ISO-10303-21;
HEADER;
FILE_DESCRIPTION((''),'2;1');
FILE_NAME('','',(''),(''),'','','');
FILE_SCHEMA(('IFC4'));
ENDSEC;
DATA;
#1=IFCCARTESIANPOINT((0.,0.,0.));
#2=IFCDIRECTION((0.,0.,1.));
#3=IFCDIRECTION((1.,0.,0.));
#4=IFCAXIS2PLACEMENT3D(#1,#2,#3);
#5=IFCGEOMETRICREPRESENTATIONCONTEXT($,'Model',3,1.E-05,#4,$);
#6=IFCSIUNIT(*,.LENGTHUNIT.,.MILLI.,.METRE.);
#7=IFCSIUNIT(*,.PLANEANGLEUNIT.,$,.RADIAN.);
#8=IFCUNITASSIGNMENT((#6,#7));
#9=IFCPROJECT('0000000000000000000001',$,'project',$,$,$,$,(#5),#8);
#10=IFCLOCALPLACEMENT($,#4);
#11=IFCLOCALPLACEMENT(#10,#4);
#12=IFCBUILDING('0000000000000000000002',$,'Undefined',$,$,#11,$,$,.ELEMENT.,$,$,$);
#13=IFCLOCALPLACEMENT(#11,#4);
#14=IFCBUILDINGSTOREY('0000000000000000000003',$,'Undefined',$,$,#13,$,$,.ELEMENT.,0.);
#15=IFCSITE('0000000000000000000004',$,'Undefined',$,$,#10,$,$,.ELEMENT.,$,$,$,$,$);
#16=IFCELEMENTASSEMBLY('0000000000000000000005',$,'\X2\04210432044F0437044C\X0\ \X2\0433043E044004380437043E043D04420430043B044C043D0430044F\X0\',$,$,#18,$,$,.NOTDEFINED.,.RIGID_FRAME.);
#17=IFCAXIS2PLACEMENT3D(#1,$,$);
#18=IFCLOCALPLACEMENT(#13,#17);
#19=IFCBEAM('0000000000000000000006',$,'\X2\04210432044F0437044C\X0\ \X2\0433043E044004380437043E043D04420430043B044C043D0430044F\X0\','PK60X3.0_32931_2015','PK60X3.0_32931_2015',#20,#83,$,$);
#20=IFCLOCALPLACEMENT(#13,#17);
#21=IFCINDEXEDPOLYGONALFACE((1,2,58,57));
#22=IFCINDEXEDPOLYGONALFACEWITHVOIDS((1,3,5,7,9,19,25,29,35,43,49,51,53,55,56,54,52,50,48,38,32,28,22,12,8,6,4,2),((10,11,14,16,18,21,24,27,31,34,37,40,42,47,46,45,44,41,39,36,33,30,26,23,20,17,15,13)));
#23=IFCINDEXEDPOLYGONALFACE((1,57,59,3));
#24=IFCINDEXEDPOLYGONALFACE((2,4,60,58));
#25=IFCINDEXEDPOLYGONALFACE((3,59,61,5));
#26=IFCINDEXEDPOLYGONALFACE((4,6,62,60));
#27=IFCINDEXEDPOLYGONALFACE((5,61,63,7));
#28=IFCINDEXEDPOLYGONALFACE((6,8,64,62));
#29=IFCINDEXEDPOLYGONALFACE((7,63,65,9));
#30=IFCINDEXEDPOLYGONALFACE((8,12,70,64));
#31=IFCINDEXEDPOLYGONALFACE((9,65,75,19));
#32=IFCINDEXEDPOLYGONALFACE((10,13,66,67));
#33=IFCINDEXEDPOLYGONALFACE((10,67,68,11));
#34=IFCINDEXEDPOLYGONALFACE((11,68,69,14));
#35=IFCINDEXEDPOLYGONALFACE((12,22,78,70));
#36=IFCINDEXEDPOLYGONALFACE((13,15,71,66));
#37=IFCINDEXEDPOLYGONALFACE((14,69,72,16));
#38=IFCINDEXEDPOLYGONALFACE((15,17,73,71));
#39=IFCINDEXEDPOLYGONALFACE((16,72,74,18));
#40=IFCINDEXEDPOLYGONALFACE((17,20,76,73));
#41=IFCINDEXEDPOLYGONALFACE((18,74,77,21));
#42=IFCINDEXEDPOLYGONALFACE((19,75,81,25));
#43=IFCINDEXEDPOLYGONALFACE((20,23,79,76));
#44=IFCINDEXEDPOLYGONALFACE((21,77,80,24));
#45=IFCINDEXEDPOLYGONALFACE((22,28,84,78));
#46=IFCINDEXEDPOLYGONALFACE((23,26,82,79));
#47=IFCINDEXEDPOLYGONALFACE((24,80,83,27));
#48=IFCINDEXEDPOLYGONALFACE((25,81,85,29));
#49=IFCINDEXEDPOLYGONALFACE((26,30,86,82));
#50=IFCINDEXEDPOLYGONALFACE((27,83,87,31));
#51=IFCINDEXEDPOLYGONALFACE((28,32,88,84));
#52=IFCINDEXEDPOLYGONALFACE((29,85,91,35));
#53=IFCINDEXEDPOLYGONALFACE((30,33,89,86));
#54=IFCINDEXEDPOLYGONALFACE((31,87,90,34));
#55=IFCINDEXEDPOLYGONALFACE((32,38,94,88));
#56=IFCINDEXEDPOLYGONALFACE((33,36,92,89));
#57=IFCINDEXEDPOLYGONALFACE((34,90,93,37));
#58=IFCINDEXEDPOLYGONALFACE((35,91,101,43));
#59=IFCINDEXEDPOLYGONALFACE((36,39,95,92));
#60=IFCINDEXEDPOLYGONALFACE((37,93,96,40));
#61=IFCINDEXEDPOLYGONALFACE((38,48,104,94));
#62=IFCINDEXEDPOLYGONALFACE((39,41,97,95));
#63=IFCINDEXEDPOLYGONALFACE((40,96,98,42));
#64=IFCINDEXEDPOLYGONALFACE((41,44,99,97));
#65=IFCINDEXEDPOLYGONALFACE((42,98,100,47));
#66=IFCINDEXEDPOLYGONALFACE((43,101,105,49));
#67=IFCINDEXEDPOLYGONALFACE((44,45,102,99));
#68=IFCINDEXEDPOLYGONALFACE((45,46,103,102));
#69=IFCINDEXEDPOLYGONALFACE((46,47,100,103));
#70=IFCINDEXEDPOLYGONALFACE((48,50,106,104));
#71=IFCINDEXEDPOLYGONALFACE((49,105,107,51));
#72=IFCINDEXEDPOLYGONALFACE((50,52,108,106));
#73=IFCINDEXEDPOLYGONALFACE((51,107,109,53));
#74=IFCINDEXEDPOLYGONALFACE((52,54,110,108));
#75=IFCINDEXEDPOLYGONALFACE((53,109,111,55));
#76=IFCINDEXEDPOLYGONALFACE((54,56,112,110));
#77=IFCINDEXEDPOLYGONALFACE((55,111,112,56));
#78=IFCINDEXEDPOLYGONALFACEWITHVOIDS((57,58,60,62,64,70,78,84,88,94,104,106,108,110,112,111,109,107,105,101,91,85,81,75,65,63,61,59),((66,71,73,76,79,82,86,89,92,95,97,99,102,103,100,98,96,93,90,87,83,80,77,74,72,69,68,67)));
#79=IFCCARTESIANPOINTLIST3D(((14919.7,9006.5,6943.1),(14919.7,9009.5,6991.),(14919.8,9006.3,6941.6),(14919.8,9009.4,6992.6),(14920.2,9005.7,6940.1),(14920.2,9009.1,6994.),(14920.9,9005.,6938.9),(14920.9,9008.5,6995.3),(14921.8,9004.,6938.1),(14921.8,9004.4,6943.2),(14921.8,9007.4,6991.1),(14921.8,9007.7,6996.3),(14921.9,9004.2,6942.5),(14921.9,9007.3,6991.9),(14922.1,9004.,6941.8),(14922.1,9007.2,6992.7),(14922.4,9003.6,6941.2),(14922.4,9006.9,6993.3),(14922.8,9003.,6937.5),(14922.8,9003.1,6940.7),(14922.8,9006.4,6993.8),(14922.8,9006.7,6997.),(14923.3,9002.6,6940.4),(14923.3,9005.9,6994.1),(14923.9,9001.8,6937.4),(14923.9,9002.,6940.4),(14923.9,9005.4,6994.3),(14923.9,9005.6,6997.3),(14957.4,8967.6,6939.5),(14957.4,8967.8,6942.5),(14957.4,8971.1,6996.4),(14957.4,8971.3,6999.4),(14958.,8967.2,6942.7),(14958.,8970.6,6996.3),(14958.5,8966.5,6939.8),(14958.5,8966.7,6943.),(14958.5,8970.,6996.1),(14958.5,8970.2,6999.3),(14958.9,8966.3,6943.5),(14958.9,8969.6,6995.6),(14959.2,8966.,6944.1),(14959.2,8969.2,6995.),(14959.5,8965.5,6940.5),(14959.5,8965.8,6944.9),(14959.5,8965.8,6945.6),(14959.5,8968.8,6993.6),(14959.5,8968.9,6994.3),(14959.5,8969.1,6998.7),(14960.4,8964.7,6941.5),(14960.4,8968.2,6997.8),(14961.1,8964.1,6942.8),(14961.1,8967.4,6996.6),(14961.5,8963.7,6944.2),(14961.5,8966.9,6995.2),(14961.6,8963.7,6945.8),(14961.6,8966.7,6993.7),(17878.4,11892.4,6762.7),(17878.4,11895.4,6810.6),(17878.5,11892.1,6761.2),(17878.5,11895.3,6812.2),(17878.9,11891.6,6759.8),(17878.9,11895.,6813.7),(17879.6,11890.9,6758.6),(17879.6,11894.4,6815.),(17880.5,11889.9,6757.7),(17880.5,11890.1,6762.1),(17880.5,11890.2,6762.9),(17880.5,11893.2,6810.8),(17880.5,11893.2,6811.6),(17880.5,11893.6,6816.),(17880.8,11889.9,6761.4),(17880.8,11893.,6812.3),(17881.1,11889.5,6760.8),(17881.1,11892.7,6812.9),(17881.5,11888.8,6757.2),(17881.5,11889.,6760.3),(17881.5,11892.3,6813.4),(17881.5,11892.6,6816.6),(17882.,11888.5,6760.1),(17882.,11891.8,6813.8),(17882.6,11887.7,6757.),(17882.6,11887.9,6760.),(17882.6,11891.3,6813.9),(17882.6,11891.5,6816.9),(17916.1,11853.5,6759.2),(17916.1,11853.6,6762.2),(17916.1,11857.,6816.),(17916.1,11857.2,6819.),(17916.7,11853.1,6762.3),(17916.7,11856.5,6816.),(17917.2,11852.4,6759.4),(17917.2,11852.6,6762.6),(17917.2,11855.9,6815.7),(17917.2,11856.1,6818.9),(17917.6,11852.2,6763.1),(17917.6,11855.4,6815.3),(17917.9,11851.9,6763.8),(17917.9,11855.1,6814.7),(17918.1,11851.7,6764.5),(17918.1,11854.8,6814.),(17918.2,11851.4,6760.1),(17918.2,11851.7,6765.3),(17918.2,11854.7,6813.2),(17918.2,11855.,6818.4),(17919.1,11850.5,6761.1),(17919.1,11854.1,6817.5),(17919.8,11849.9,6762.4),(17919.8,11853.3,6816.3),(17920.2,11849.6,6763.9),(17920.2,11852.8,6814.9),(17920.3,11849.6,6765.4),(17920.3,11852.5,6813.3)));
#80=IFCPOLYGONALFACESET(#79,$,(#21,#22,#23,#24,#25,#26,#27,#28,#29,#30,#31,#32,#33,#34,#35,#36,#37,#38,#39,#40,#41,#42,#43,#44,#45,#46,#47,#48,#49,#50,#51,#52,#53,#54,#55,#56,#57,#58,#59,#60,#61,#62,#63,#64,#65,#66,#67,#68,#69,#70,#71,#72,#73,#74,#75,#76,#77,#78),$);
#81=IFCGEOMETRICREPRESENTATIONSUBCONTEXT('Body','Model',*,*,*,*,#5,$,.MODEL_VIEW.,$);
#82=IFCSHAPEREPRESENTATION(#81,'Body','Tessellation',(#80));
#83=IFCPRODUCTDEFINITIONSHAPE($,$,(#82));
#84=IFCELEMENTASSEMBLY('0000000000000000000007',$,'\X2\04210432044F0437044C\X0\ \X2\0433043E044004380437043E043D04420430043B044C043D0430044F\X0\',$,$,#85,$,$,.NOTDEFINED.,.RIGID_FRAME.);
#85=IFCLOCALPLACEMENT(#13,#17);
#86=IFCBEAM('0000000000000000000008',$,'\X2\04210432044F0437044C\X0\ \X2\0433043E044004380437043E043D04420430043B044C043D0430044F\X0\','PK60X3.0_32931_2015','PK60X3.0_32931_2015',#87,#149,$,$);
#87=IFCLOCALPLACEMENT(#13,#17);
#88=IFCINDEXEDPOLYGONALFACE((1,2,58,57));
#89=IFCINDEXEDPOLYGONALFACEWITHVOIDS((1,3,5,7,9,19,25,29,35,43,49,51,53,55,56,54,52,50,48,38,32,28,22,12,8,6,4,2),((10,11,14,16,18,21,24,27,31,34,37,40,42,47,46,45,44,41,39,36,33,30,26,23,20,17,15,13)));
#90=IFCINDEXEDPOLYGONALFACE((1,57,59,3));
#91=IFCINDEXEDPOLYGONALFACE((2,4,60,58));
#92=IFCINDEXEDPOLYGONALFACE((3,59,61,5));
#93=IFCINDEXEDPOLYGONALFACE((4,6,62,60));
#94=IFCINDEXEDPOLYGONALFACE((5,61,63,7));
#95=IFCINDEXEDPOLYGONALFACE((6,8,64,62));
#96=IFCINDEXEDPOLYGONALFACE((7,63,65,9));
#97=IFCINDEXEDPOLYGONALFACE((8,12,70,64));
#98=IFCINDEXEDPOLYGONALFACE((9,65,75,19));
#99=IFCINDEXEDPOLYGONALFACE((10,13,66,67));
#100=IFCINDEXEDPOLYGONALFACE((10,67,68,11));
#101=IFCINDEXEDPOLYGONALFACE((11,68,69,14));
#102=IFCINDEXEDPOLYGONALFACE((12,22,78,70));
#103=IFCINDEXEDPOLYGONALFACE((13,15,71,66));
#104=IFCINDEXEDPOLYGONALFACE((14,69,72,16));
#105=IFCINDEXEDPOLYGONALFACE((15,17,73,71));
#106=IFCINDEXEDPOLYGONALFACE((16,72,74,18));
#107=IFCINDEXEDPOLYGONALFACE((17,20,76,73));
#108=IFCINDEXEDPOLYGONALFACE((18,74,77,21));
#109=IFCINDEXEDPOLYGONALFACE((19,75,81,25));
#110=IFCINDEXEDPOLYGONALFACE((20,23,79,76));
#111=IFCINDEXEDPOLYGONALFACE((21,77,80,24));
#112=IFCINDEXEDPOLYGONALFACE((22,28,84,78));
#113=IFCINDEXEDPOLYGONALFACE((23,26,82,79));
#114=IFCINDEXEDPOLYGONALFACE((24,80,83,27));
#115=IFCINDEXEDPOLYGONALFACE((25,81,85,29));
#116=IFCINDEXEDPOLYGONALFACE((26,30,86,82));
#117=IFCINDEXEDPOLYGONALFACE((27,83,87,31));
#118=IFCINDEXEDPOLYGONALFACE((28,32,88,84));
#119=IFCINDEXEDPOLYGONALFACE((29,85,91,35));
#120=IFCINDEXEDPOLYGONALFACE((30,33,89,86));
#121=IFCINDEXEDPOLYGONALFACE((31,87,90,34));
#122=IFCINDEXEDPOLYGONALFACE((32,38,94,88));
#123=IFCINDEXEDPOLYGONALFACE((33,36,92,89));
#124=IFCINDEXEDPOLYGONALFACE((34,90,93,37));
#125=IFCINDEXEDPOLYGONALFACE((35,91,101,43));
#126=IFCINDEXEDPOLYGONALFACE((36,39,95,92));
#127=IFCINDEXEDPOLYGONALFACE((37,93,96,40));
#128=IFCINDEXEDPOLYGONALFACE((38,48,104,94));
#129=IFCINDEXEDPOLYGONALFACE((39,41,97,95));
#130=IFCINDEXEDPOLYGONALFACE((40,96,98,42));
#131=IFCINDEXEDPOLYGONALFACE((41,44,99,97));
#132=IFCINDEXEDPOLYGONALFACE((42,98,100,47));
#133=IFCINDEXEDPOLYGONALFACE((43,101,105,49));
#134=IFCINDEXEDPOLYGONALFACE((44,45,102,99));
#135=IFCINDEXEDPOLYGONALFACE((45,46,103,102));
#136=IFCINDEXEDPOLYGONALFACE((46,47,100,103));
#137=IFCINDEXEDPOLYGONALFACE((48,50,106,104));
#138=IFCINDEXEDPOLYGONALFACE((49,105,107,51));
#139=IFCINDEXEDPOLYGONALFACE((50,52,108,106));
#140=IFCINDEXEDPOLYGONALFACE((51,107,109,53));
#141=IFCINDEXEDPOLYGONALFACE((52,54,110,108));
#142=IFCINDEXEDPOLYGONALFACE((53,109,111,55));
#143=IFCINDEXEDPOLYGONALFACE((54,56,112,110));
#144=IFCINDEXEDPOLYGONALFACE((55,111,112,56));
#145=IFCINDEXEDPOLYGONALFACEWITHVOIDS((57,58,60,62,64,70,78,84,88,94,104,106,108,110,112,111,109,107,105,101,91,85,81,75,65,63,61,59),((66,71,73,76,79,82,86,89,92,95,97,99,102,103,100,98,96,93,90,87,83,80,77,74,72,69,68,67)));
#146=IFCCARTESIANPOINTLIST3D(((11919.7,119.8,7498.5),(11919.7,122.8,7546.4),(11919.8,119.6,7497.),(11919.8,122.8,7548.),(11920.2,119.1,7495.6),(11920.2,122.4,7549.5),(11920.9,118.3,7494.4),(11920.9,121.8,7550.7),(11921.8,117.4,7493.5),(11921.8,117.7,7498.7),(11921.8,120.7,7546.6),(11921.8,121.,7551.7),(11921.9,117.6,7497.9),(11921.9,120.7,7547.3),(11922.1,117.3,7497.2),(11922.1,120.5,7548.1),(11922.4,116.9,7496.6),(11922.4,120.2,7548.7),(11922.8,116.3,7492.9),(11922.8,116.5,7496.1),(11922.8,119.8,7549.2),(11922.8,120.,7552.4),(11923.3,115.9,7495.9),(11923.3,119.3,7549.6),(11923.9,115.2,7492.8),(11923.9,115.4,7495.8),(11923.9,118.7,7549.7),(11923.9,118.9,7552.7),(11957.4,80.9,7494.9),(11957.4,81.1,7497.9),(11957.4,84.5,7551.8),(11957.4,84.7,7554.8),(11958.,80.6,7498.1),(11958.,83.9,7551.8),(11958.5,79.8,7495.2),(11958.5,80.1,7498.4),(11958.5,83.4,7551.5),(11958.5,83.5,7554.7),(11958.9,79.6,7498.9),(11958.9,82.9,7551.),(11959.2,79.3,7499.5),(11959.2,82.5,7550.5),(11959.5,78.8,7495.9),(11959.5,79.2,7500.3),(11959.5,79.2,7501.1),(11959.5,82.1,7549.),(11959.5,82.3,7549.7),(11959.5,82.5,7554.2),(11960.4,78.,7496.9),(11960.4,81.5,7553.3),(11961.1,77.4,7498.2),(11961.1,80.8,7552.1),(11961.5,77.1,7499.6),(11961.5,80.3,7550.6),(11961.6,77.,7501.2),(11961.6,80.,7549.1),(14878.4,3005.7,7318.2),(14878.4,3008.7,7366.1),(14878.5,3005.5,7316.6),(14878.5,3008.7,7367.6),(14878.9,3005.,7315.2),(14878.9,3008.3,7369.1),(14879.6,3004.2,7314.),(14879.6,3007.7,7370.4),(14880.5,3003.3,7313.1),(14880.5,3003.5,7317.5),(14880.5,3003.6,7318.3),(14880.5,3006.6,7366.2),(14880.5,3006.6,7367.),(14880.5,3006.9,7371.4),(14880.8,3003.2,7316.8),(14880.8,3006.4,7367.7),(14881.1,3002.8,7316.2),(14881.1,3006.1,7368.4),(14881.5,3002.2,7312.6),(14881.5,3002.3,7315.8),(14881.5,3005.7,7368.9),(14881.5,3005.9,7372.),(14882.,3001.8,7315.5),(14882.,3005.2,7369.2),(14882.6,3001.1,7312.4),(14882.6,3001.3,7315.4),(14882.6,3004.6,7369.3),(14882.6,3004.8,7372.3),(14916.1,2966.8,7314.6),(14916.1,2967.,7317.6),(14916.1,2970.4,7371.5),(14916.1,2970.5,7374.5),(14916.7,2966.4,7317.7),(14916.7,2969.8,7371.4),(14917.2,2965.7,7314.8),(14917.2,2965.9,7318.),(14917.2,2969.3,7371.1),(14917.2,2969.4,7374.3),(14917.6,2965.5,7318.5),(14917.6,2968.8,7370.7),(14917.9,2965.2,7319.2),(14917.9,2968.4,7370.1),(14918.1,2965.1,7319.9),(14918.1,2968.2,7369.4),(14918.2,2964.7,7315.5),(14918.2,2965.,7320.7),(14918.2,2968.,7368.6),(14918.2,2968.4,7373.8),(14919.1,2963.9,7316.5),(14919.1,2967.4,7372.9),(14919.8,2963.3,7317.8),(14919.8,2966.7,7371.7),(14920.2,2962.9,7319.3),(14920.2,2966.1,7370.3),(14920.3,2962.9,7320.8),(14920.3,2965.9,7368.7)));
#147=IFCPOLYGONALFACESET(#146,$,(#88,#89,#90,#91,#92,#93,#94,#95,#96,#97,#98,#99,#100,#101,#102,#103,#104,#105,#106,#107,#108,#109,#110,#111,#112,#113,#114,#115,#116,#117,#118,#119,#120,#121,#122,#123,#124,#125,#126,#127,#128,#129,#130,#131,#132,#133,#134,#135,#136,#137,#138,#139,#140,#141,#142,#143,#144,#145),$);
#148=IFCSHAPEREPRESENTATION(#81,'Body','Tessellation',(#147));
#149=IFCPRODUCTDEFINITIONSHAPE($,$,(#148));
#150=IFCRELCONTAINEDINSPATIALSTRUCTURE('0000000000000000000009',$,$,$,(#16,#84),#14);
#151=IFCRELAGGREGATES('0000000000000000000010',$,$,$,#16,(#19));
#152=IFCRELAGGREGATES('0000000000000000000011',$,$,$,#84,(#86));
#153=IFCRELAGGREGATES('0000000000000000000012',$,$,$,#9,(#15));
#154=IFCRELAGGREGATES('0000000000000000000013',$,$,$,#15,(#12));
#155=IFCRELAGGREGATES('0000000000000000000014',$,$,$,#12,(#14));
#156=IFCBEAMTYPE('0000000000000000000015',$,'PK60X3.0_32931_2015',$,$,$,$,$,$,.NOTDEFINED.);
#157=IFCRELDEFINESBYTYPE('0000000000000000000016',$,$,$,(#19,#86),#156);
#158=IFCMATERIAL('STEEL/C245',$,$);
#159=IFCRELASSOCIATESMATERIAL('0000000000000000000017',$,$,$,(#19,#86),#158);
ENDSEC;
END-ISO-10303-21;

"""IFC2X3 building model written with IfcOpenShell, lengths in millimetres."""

from ifc_helpers import new_model, si_unit, frame, origin_with_axes, origin_2d_with_axis, place, context, subcontext, project, spatial, hollow_rectangle, extrude, material, type_object, element, aggregate, save


model = new_model("IFC2X3")

# Units and contexts
model_context = context("Model", 3, precision=1e-05, world=origin_with_axes())
body_context = subcontext(model_context, "Body", "Model", "MODEL_VIEW")
ifc_project = project(units=[si_unit("LENGTHUNIT", "METRE", prefix="MILLI"), si_unit("PLANEANGLEUNIT", "RADIAN")], contexts=[model_context])

# Site, building, storey
site_placement = place(None, origin_with_axes())
site = spatial("IfcSite", under=ifc_project, at=site_placement, Name="Undefined", CompositionType="ELEMENT")
building_placement = place(site_placement, origin_with_axes())
building = spatial("IfcBuilding", under=site, at=building_placement, Name="Undefined", CompositionType="ELEMENT")
storey_placement = place(building_placement, origin_with_axes())
storey = spatial("IfcBuildingStorey", under=building, at=storey_placement, Name="Undefined", CompositionType="ELEMENT", Elevation=0.0)

# Shared definitions
ifc_material = material(Name="STEEL/C245")

# Element assemblies, beams
beam_type_1 = type_object("IfcBeamType", Name="PK60X3.0_32931_2015", PredefinedType="NOTDEFINED")
assembly_1_placement = place(storey_placement, origin_with_axes())
assembly_1 = element("IfcElementAssembly", 1, at=assembly_1_placement, inside=storey, Name="Связь горизонтальная", AssemblyPlace="NOTDEFINED", PredefinedType="RIGID_FRAME")
beam_1_placement = place(assembly_1_placement, frame((17899.3, 11872.5, 6788.0), z_axis=(0.0, 0.062378, 0.998053), x_axis=(-0.715179, -0.69758, 0.043599)))
beam_1 = element("IfcBeam", 2, at=beam_1_placement, type_object=beam_type_1, material=ifc_material, Name="Связь горизонтальная", Description="PK60X3.0_32931_2015", ObjectType="PK60X3.0_32931_2015", context=body_context, shape_type="SweptSolid", body=[
    extrude(hollow_rectangle(XDim=60.0, YDim=60.0, WallThickness=3.0, InnerFilletRadius=3.0, OuterFilletRadius=6.0, at=origin_2d_with_axis()), frame((4137.0, 0.0, 0.0), z_axis=(-1.0, 0.0, 0.0), x_axis=(0.0, -1.0, 0.0)), (0.0, 0.0, 1.0), 4137.0),
])
aggregate(assembly_1, [beam_1])
assembly_2_placement = place(storey_placement, origin_with_axes())
assembly_2 = element("IfcElementAssembly", 3, at=assembly_2_placement, inside=storey, Name="Связь горизонтальная", AssemblyPlace="NOTDEFINED", PredefinedType="RIGID_FRAME")
beam_2_placement = place(assembly_2_placement, frame((11940.7, 99.9, 7523.8), z_axis=(0.0, 0.062378, 0.998053), x_axis=(0.715179, 0.69758, -0.043599)))
beam_2 = element("IfcBeam", 4, at=beam_2_placement, type_object=beam_type_1, material=ifc_material, Name="Связь горизонтальная", Description="PK60X3.0_32931_2015", ObjectType="PK60X3.0_32931_2015", context=body_context, shape_type="SweptSolid", body=[
    extrude(hollow_rectangle(XDim=60.0, YDim=60.0, WallThickness=3.0, InnerFilletRadius=3.0, OuterFilletRadius=6.0, at=origin_2d_with_axis()), frame((4137.0, 0.0, 0.0), z_axis=(-1.0, 0.0, 0.0), x_axis=(0.0, -1.0, 0.0)), (0.0, 0.0, 1.0), 4137.0),
])
aggregate(assembly_2, [beam_2])

save(model, "model.ifc")
